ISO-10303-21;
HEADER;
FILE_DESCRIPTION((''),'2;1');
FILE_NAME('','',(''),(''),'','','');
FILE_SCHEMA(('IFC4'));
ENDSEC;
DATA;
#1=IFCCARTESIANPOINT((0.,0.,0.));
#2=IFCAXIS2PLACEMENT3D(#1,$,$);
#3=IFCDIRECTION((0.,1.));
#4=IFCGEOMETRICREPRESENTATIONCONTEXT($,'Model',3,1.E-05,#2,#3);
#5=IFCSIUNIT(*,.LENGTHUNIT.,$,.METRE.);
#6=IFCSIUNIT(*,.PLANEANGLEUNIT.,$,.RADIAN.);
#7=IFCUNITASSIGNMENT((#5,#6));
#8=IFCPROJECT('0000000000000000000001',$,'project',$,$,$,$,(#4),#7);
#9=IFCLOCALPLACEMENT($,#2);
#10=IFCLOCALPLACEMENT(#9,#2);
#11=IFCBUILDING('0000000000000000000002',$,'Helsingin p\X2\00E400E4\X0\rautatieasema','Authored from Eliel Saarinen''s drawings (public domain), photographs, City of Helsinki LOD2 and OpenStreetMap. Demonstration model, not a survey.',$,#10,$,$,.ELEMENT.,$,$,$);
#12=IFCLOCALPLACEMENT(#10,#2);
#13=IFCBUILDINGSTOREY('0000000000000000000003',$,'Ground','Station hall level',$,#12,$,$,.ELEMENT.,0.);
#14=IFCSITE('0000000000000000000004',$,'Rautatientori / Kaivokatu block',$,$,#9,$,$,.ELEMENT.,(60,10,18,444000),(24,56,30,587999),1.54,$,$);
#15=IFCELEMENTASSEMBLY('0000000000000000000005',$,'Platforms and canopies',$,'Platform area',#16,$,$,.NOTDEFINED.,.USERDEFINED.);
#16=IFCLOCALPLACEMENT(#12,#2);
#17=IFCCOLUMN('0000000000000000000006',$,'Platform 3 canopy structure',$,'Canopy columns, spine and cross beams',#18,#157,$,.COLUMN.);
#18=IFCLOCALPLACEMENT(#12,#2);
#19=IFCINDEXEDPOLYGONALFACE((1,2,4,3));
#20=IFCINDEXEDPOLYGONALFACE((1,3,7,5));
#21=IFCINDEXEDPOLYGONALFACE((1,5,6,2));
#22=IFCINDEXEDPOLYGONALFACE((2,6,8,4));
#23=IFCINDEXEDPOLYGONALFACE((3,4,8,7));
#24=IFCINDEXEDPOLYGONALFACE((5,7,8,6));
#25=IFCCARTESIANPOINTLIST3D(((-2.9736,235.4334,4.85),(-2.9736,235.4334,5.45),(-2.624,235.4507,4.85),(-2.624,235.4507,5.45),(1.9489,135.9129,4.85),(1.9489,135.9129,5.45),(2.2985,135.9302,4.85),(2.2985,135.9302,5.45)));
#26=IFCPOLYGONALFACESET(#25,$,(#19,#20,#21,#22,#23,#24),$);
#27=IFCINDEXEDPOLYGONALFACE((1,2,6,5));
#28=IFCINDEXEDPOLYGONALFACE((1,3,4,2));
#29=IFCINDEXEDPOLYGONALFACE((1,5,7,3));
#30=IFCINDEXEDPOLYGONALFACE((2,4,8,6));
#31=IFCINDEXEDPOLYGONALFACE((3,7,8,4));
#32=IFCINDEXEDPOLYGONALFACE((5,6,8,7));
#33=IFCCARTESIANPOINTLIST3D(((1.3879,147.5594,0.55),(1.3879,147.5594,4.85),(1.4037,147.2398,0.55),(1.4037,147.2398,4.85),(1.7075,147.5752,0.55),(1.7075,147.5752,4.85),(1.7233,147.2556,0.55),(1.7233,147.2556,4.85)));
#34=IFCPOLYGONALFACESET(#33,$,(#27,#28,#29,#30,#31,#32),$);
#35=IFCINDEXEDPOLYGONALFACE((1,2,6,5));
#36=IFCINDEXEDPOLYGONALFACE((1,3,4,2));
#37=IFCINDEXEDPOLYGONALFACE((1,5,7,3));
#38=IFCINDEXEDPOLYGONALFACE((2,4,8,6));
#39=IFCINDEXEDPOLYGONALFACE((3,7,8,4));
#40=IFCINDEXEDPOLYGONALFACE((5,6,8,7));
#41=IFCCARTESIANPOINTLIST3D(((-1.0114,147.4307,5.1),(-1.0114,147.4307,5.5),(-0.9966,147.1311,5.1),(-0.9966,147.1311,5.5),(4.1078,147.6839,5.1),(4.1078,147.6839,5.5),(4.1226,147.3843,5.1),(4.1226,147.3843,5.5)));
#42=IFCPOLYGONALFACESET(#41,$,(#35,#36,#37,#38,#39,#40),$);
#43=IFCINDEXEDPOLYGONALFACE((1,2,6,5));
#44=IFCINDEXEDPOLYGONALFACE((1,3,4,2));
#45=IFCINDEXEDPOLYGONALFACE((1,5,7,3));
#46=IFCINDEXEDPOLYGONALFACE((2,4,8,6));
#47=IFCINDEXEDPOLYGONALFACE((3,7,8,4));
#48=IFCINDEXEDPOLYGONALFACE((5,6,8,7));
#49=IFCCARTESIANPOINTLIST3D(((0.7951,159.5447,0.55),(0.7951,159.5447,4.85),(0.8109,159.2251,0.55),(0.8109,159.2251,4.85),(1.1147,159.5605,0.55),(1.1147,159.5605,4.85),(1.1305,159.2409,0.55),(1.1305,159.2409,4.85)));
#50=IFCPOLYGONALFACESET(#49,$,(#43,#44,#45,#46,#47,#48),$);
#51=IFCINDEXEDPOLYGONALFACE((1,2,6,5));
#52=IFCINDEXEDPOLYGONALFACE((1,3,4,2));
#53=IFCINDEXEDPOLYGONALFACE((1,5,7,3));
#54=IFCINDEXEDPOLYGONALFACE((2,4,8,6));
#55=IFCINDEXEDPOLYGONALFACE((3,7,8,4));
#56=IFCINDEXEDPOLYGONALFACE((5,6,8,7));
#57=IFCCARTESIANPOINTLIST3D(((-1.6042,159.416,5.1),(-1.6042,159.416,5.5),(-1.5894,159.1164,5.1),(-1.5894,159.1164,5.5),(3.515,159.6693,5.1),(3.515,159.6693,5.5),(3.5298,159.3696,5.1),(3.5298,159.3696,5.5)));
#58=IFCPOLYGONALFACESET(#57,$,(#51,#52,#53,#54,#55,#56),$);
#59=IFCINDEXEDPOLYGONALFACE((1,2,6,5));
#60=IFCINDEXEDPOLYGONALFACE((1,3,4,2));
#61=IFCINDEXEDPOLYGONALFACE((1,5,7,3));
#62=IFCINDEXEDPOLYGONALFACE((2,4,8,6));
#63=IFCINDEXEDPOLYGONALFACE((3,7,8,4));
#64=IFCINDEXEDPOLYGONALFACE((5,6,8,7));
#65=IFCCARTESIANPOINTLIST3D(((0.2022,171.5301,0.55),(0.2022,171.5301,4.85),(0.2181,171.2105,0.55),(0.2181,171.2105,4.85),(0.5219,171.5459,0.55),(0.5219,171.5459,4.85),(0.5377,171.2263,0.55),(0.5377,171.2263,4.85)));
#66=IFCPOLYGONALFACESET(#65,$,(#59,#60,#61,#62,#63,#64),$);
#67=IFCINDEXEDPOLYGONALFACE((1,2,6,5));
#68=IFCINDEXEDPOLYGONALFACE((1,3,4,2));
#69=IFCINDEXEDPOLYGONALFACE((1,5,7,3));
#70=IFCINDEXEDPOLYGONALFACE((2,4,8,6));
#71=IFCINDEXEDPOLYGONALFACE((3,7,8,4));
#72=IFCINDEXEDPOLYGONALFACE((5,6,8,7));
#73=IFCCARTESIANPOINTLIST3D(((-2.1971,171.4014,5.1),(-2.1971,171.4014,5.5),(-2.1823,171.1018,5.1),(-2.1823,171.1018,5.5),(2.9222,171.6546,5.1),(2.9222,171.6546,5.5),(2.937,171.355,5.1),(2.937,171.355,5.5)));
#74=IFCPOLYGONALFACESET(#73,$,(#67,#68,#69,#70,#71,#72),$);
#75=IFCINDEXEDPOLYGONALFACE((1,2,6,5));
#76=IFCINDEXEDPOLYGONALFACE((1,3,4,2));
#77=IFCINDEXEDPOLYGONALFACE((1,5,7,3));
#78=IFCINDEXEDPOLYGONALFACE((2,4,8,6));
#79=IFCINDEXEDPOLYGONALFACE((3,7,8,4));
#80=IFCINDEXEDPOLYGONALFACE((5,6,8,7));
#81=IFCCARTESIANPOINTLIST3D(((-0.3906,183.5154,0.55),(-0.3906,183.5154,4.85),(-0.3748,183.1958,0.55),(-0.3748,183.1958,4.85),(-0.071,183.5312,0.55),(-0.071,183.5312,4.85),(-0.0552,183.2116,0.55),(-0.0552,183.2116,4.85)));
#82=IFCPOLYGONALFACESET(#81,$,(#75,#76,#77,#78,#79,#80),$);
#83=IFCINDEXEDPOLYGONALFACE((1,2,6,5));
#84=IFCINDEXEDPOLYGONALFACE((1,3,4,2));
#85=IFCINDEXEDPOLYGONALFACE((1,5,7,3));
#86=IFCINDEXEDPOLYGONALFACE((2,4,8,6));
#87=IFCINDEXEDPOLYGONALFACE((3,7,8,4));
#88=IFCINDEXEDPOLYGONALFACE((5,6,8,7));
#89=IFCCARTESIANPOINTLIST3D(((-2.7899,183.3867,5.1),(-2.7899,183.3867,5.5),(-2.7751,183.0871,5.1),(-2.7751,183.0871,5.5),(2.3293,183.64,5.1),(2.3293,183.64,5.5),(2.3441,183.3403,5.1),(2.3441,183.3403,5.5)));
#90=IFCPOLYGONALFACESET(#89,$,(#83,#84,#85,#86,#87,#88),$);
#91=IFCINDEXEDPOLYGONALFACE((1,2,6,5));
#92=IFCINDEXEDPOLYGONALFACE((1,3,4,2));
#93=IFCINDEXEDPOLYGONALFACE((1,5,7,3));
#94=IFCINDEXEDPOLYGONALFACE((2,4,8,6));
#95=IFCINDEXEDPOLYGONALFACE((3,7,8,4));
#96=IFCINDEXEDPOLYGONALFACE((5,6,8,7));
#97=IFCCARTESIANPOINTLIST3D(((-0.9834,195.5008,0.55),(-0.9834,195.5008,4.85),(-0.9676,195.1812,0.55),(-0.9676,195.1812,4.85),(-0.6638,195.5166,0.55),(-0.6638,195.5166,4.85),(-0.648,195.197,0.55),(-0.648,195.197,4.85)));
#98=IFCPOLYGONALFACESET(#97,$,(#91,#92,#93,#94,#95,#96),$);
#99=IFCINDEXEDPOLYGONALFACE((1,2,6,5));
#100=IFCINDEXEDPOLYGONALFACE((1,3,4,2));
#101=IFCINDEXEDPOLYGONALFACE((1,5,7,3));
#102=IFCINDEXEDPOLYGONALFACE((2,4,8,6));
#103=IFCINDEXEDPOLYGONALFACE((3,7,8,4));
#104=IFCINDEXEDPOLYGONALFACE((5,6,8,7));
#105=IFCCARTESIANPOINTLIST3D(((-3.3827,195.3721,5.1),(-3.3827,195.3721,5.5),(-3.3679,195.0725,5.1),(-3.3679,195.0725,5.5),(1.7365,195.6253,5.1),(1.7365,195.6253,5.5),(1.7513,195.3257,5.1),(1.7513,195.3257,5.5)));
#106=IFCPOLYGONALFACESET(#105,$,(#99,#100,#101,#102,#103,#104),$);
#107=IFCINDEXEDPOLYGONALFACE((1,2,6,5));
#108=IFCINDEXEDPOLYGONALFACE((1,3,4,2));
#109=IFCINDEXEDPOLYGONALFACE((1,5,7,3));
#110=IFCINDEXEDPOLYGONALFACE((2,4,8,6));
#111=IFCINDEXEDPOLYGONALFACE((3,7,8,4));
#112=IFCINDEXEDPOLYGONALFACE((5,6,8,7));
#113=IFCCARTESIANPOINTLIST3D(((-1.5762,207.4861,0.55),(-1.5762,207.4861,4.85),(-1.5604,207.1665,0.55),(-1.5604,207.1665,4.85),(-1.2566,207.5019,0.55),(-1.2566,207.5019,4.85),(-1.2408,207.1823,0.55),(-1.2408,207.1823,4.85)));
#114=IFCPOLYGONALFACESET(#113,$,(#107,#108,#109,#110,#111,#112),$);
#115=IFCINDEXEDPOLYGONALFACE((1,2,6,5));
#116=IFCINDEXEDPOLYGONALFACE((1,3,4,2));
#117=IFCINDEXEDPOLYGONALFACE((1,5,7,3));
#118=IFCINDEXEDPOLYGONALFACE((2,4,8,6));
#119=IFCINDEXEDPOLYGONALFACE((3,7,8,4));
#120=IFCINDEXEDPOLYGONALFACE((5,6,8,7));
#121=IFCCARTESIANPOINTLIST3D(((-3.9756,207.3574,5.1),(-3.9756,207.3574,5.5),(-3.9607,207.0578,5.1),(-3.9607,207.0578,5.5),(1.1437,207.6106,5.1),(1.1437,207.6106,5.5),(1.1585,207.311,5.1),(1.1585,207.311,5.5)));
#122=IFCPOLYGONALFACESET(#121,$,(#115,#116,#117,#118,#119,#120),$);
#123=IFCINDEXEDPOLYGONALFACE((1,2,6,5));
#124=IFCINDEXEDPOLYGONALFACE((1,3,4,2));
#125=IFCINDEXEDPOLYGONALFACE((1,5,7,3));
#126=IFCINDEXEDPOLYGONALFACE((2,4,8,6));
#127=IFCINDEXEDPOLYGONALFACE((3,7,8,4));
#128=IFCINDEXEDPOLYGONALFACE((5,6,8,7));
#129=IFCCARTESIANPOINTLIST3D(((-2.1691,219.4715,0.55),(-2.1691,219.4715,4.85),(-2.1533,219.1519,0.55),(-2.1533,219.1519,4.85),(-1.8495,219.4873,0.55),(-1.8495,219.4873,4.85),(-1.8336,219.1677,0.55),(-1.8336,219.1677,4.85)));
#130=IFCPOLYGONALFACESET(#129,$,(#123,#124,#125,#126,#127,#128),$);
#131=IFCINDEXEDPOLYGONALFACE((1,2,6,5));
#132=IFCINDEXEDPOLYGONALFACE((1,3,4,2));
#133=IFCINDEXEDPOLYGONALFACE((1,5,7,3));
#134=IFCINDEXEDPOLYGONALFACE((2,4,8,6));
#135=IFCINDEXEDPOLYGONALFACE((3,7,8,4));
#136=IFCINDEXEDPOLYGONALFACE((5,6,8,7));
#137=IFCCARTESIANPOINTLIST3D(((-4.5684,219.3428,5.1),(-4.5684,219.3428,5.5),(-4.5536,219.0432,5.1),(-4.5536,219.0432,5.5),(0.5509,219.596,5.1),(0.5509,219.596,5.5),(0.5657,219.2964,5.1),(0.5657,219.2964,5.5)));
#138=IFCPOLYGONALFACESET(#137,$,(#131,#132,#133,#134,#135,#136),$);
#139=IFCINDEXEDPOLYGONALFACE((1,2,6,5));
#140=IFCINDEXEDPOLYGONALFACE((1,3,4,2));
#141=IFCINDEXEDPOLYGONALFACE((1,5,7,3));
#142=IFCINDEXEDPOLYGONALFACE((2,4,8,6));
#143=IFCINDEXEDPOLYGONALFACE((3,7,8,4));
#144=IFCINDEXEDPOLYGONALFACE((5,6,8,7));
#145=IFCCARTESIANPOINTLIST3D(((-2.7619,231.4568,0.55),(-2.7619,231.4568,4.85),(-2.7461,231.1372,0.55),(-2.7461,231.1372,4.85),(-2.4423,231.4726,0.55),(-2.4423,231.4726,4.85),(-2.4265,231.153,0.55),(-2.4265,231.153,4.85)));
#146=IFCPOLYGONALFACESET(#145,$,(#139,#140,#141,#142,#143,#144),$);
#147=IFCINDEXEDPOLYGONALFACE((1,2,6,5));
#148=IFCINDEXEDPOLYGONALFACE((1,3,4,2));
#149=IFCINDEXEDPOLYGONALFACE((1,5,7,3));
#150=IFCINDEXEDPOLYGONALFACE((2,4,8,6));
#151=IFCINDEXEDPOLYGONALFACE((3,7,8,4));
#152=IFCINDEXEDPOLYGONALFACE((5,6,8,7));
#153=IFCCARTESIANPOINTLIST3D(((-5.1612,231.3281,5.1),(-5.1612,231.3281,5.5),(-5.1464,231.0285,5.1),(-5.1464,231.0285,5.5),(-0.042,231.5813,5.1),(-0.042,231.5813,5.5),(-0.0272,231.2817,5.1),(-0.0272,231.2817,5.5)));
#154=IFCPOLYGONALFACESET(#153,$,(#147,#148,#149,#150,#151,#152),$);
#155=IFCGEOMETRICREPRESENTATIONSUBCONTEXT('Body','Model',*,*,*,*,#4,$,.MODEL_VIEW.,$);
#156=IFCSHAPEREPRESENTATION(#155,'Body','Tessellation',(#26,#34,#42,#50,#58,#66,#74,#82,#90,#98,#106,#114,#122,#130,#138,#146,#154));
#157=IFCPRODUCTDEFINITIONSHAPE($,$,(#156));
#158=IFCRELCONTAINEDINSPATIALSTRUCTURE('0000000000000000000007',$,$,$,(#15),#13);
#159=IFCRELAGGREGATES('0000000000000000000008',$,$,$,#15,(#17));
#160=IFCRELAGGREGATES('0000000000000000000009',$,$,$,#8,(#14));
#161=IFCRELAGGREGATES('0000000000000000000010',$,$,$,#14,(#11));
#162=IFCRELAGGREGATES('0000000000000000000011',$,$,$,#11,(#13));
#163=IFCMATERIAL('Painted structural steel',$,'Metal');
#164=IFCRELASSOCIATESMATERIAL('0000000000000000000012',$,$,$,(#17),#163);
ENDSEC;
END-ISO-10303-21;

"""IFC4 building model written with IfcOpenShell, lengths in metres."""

from ifc_helpers import new_model, si_unit, direction, frame, frame_2d, origin, place, context, subcontext, project, spatial, rectangle, extrude, material, element, aggregate, save


model = new_model("IFC4")

# Units and contexts
model_context = context("Model", 3, precision=1e-05, world=origin(), true_north=direction((0.0, 1.0)))
body_context = subcontext(model_context, "Body", "Model", "MODEL_VIEW")
ifc_project = project(units=[si_unit("LENGTHUNIT", "METRE"), si_unit("PLANEANGLEUNIT", "RADIAN")], contexts=[model_context])

# Site, building, storey
site_placement = place(None, origin())
site = spatial("IfcSite", under=ifc_project, at=site_placement, Name="Rautatientori / Kaivokatu block", CompositionType="ELEMENT", RefLatitude=(60, 10, 18, 444000), RefLongitude=(24, 56, 30, 587999), RefElevation=1.54)
building_placement = place(site_placement, origin())
building = spatial("IfcBuilding", under=site, at=building_placement, Name="Helsingin päärautatieasema", Description="Authored from Eliel Saarinen's drawings (public domain), photographs, City of Helsinki LOD2 and OpenStreetMap. Demonstration model, not a survey.", CompositionType="ELEMENT")
storey_placement = place(building_placement, origin())
storey = spatial("IfcBuildingStorey", under=building, at=storey_placement, Name="Ground", Description="Station hall level", CompositionType="ELEMENT", Elevation=0.0)

# Element assembly, column
assembly_placement = place(building_placement, origin())
assembly = element("IfcElementAssembly", 1, at=assembly_placement, inside=storey, Name="Platforms and canopies", ObjectType="Platform area", AssemblyPlace="NOTDEFINED", PredefinedType="USERDEFINED")
ifc_material_1 = material(Name="Painted structural steel", Category="Metal")
column_1_placement = place(building_placement, origin())
column_1 = element("IfcColumn", 2, at=column_1_placement, material=ifc_material_1, Name="Platform 3 canopy structure", ObjectType="Canopy columns, spine and cross beams", PredefinedType="COLUMN", context=body_context, shape_type="SweptSolid", body=[
    extrude(rectangle(XDim=99.6422, YDim=0.35, at=frame_2d((0.0, 0.0), x_axis=(-0.049402, 0.998779))), frame((-0.3375, 185.6818, 4.85)), (0.0, 0.0, 1.0), 0.6),
    extrude(rectangle(XDim=0.32, YDim=0.32, at=frame_2d((0.0, 0.0), x_axis=(-0.049402, 0.998779))), frame((1.5556, 147.4075, 0.55)), (0.0, 0.0, 1.0), 4.3),
    extrude(rectangle(XDim=0.3, YDim=5.1255, at=frame_2d((0.0, 0.0), x_axis=(-0.049402, 0.998779))), frame((1.5556, 147.4075, 5.1)), (0.0, 0.0, 1.0), 0.4),
    extrude(rectangle(XDim=0.32, YDim=0.32, at=frame_2d((0.0, 0.0), x_axis=(-0.049402, 0.998779))), frame((0.9628, 159.3928, 0.55)), (0.0, 0.0, 1.0), 4.3),
    extrude(rectangle(XDim=0.3, YDim=5.1255, at=frame_2d((0.0, 0.0), x_axis=(-0.049402, 0.998779))), frame((0.9628, 159.3928, 5.1)), (0.0, 0.0, 1.0), 0.4),
    extrude(rectangle(XDim=0.32, YDim=0.32, at=frame_2d((0.0, 0.0), x_axis=(-0.049402, 0.998779))), frame((0.37, 171.3782, 0.55)), (0.0, 0.0, 1.0), 4.3),
    extrude(rectangle(XDim=0.3, YDim=5.1255, at=frame_2d((0.0, 0.0), x_axis=(-0.049402, 0.998779))), frame((0.37, 171.3782, 5.1)), (0.0, 0.0, 1.0), 0.4),
    extrude(rectangle(XDim=0.32, YDim=0.32, at=frame_2d((0.0, 0.0), x_axis=(-0.049402, 0.998779))), frame((-0.2229, 183.3635, 0.55)), (0.0, 0.0, 1.0), 4.3),
    extrude(rectangle(XDim=0.3, YDim=5.1255, at=frame_2d((0.0, 0.0), x_axis=(-0.049402, 0.998779))), frame((-0.2229, 183.3635, 5.1)), (0.0, 0.0, 1.0), 0.4),
    extrude(rectangle(XDim=0.32, YDim=0.32, at=frame_2d((0.0, 0.0), x_axis=(-0.049402, 0.998779))), frame((-0.8157, 195.3489, 0.55)), (0.0, 0.0, 1.0), 4.3),
    extrude(rectangle(XDim=0.3, YDim=5.1255, at=frame_2d((0.0, 0.0), x_axis=(-0.049402, 0.998779))), frame((-0.8157, 195.3489, 5.1)), (0.0, 0.0, 1.0), 0.4),
    extrude(rectangle(XDim=0.32, YDim=0.32, at=frame_2d((0.0, 0.0), x_axis=(-0.049402, 0.998779))), frame((-1.4085, 207.3342, 0.55)), (0.0, 0.0, 1.0), 4.3),
    extrude(rectangle(XDim=0.3, YDim=5.1255, at=frame_2d((0.0, 0.0), x_axis=(-0.049402, 0.998779))), frame((-1.4085, 207.3342, 5.1)), (0.0, 0.0, 1.0), 0.4),
    extrude(rectangle(XDim=0.32, YDim=0.32, at=frame_2d((0.0, 0.0), x_axis=(-0.049402, 0.998779))), frame((-2.0014, 219.3196, 0.55)), (0.0, 0.0, 1.0), 4.3),
    extrude(rectangle(XDim=0.3, YDim=5.1255, at=frame_2d((0.0, 0.0), x_axis=(-0.049402, 0.998779))), frame((-2.0014, 219.3196, 5.1)), (0.0, 0.0, 1.0), 0.4),
    extrude(rectangle(XDim=0.32, YDim=0.32, at=frame_2d((0.0, 0.0), x_axis=(-0.049402, 0.998779))), frame((-2.5942, 231.3049, 0.55)), (0.0, 0.0, 1.0), 4.3),
    extrude(rectangle(XDim=0.3, YDim=5.1255, at=frame_2d((0.0, 0.0), x_axis=(-0.049402, 0.998779))), frame((-2.5942, 231.3049, 5.1)), (0.0, 0.0, 1.0), 0.4),
])
aggregate(assembly, [column_1])

save(model, "model.ifc")
